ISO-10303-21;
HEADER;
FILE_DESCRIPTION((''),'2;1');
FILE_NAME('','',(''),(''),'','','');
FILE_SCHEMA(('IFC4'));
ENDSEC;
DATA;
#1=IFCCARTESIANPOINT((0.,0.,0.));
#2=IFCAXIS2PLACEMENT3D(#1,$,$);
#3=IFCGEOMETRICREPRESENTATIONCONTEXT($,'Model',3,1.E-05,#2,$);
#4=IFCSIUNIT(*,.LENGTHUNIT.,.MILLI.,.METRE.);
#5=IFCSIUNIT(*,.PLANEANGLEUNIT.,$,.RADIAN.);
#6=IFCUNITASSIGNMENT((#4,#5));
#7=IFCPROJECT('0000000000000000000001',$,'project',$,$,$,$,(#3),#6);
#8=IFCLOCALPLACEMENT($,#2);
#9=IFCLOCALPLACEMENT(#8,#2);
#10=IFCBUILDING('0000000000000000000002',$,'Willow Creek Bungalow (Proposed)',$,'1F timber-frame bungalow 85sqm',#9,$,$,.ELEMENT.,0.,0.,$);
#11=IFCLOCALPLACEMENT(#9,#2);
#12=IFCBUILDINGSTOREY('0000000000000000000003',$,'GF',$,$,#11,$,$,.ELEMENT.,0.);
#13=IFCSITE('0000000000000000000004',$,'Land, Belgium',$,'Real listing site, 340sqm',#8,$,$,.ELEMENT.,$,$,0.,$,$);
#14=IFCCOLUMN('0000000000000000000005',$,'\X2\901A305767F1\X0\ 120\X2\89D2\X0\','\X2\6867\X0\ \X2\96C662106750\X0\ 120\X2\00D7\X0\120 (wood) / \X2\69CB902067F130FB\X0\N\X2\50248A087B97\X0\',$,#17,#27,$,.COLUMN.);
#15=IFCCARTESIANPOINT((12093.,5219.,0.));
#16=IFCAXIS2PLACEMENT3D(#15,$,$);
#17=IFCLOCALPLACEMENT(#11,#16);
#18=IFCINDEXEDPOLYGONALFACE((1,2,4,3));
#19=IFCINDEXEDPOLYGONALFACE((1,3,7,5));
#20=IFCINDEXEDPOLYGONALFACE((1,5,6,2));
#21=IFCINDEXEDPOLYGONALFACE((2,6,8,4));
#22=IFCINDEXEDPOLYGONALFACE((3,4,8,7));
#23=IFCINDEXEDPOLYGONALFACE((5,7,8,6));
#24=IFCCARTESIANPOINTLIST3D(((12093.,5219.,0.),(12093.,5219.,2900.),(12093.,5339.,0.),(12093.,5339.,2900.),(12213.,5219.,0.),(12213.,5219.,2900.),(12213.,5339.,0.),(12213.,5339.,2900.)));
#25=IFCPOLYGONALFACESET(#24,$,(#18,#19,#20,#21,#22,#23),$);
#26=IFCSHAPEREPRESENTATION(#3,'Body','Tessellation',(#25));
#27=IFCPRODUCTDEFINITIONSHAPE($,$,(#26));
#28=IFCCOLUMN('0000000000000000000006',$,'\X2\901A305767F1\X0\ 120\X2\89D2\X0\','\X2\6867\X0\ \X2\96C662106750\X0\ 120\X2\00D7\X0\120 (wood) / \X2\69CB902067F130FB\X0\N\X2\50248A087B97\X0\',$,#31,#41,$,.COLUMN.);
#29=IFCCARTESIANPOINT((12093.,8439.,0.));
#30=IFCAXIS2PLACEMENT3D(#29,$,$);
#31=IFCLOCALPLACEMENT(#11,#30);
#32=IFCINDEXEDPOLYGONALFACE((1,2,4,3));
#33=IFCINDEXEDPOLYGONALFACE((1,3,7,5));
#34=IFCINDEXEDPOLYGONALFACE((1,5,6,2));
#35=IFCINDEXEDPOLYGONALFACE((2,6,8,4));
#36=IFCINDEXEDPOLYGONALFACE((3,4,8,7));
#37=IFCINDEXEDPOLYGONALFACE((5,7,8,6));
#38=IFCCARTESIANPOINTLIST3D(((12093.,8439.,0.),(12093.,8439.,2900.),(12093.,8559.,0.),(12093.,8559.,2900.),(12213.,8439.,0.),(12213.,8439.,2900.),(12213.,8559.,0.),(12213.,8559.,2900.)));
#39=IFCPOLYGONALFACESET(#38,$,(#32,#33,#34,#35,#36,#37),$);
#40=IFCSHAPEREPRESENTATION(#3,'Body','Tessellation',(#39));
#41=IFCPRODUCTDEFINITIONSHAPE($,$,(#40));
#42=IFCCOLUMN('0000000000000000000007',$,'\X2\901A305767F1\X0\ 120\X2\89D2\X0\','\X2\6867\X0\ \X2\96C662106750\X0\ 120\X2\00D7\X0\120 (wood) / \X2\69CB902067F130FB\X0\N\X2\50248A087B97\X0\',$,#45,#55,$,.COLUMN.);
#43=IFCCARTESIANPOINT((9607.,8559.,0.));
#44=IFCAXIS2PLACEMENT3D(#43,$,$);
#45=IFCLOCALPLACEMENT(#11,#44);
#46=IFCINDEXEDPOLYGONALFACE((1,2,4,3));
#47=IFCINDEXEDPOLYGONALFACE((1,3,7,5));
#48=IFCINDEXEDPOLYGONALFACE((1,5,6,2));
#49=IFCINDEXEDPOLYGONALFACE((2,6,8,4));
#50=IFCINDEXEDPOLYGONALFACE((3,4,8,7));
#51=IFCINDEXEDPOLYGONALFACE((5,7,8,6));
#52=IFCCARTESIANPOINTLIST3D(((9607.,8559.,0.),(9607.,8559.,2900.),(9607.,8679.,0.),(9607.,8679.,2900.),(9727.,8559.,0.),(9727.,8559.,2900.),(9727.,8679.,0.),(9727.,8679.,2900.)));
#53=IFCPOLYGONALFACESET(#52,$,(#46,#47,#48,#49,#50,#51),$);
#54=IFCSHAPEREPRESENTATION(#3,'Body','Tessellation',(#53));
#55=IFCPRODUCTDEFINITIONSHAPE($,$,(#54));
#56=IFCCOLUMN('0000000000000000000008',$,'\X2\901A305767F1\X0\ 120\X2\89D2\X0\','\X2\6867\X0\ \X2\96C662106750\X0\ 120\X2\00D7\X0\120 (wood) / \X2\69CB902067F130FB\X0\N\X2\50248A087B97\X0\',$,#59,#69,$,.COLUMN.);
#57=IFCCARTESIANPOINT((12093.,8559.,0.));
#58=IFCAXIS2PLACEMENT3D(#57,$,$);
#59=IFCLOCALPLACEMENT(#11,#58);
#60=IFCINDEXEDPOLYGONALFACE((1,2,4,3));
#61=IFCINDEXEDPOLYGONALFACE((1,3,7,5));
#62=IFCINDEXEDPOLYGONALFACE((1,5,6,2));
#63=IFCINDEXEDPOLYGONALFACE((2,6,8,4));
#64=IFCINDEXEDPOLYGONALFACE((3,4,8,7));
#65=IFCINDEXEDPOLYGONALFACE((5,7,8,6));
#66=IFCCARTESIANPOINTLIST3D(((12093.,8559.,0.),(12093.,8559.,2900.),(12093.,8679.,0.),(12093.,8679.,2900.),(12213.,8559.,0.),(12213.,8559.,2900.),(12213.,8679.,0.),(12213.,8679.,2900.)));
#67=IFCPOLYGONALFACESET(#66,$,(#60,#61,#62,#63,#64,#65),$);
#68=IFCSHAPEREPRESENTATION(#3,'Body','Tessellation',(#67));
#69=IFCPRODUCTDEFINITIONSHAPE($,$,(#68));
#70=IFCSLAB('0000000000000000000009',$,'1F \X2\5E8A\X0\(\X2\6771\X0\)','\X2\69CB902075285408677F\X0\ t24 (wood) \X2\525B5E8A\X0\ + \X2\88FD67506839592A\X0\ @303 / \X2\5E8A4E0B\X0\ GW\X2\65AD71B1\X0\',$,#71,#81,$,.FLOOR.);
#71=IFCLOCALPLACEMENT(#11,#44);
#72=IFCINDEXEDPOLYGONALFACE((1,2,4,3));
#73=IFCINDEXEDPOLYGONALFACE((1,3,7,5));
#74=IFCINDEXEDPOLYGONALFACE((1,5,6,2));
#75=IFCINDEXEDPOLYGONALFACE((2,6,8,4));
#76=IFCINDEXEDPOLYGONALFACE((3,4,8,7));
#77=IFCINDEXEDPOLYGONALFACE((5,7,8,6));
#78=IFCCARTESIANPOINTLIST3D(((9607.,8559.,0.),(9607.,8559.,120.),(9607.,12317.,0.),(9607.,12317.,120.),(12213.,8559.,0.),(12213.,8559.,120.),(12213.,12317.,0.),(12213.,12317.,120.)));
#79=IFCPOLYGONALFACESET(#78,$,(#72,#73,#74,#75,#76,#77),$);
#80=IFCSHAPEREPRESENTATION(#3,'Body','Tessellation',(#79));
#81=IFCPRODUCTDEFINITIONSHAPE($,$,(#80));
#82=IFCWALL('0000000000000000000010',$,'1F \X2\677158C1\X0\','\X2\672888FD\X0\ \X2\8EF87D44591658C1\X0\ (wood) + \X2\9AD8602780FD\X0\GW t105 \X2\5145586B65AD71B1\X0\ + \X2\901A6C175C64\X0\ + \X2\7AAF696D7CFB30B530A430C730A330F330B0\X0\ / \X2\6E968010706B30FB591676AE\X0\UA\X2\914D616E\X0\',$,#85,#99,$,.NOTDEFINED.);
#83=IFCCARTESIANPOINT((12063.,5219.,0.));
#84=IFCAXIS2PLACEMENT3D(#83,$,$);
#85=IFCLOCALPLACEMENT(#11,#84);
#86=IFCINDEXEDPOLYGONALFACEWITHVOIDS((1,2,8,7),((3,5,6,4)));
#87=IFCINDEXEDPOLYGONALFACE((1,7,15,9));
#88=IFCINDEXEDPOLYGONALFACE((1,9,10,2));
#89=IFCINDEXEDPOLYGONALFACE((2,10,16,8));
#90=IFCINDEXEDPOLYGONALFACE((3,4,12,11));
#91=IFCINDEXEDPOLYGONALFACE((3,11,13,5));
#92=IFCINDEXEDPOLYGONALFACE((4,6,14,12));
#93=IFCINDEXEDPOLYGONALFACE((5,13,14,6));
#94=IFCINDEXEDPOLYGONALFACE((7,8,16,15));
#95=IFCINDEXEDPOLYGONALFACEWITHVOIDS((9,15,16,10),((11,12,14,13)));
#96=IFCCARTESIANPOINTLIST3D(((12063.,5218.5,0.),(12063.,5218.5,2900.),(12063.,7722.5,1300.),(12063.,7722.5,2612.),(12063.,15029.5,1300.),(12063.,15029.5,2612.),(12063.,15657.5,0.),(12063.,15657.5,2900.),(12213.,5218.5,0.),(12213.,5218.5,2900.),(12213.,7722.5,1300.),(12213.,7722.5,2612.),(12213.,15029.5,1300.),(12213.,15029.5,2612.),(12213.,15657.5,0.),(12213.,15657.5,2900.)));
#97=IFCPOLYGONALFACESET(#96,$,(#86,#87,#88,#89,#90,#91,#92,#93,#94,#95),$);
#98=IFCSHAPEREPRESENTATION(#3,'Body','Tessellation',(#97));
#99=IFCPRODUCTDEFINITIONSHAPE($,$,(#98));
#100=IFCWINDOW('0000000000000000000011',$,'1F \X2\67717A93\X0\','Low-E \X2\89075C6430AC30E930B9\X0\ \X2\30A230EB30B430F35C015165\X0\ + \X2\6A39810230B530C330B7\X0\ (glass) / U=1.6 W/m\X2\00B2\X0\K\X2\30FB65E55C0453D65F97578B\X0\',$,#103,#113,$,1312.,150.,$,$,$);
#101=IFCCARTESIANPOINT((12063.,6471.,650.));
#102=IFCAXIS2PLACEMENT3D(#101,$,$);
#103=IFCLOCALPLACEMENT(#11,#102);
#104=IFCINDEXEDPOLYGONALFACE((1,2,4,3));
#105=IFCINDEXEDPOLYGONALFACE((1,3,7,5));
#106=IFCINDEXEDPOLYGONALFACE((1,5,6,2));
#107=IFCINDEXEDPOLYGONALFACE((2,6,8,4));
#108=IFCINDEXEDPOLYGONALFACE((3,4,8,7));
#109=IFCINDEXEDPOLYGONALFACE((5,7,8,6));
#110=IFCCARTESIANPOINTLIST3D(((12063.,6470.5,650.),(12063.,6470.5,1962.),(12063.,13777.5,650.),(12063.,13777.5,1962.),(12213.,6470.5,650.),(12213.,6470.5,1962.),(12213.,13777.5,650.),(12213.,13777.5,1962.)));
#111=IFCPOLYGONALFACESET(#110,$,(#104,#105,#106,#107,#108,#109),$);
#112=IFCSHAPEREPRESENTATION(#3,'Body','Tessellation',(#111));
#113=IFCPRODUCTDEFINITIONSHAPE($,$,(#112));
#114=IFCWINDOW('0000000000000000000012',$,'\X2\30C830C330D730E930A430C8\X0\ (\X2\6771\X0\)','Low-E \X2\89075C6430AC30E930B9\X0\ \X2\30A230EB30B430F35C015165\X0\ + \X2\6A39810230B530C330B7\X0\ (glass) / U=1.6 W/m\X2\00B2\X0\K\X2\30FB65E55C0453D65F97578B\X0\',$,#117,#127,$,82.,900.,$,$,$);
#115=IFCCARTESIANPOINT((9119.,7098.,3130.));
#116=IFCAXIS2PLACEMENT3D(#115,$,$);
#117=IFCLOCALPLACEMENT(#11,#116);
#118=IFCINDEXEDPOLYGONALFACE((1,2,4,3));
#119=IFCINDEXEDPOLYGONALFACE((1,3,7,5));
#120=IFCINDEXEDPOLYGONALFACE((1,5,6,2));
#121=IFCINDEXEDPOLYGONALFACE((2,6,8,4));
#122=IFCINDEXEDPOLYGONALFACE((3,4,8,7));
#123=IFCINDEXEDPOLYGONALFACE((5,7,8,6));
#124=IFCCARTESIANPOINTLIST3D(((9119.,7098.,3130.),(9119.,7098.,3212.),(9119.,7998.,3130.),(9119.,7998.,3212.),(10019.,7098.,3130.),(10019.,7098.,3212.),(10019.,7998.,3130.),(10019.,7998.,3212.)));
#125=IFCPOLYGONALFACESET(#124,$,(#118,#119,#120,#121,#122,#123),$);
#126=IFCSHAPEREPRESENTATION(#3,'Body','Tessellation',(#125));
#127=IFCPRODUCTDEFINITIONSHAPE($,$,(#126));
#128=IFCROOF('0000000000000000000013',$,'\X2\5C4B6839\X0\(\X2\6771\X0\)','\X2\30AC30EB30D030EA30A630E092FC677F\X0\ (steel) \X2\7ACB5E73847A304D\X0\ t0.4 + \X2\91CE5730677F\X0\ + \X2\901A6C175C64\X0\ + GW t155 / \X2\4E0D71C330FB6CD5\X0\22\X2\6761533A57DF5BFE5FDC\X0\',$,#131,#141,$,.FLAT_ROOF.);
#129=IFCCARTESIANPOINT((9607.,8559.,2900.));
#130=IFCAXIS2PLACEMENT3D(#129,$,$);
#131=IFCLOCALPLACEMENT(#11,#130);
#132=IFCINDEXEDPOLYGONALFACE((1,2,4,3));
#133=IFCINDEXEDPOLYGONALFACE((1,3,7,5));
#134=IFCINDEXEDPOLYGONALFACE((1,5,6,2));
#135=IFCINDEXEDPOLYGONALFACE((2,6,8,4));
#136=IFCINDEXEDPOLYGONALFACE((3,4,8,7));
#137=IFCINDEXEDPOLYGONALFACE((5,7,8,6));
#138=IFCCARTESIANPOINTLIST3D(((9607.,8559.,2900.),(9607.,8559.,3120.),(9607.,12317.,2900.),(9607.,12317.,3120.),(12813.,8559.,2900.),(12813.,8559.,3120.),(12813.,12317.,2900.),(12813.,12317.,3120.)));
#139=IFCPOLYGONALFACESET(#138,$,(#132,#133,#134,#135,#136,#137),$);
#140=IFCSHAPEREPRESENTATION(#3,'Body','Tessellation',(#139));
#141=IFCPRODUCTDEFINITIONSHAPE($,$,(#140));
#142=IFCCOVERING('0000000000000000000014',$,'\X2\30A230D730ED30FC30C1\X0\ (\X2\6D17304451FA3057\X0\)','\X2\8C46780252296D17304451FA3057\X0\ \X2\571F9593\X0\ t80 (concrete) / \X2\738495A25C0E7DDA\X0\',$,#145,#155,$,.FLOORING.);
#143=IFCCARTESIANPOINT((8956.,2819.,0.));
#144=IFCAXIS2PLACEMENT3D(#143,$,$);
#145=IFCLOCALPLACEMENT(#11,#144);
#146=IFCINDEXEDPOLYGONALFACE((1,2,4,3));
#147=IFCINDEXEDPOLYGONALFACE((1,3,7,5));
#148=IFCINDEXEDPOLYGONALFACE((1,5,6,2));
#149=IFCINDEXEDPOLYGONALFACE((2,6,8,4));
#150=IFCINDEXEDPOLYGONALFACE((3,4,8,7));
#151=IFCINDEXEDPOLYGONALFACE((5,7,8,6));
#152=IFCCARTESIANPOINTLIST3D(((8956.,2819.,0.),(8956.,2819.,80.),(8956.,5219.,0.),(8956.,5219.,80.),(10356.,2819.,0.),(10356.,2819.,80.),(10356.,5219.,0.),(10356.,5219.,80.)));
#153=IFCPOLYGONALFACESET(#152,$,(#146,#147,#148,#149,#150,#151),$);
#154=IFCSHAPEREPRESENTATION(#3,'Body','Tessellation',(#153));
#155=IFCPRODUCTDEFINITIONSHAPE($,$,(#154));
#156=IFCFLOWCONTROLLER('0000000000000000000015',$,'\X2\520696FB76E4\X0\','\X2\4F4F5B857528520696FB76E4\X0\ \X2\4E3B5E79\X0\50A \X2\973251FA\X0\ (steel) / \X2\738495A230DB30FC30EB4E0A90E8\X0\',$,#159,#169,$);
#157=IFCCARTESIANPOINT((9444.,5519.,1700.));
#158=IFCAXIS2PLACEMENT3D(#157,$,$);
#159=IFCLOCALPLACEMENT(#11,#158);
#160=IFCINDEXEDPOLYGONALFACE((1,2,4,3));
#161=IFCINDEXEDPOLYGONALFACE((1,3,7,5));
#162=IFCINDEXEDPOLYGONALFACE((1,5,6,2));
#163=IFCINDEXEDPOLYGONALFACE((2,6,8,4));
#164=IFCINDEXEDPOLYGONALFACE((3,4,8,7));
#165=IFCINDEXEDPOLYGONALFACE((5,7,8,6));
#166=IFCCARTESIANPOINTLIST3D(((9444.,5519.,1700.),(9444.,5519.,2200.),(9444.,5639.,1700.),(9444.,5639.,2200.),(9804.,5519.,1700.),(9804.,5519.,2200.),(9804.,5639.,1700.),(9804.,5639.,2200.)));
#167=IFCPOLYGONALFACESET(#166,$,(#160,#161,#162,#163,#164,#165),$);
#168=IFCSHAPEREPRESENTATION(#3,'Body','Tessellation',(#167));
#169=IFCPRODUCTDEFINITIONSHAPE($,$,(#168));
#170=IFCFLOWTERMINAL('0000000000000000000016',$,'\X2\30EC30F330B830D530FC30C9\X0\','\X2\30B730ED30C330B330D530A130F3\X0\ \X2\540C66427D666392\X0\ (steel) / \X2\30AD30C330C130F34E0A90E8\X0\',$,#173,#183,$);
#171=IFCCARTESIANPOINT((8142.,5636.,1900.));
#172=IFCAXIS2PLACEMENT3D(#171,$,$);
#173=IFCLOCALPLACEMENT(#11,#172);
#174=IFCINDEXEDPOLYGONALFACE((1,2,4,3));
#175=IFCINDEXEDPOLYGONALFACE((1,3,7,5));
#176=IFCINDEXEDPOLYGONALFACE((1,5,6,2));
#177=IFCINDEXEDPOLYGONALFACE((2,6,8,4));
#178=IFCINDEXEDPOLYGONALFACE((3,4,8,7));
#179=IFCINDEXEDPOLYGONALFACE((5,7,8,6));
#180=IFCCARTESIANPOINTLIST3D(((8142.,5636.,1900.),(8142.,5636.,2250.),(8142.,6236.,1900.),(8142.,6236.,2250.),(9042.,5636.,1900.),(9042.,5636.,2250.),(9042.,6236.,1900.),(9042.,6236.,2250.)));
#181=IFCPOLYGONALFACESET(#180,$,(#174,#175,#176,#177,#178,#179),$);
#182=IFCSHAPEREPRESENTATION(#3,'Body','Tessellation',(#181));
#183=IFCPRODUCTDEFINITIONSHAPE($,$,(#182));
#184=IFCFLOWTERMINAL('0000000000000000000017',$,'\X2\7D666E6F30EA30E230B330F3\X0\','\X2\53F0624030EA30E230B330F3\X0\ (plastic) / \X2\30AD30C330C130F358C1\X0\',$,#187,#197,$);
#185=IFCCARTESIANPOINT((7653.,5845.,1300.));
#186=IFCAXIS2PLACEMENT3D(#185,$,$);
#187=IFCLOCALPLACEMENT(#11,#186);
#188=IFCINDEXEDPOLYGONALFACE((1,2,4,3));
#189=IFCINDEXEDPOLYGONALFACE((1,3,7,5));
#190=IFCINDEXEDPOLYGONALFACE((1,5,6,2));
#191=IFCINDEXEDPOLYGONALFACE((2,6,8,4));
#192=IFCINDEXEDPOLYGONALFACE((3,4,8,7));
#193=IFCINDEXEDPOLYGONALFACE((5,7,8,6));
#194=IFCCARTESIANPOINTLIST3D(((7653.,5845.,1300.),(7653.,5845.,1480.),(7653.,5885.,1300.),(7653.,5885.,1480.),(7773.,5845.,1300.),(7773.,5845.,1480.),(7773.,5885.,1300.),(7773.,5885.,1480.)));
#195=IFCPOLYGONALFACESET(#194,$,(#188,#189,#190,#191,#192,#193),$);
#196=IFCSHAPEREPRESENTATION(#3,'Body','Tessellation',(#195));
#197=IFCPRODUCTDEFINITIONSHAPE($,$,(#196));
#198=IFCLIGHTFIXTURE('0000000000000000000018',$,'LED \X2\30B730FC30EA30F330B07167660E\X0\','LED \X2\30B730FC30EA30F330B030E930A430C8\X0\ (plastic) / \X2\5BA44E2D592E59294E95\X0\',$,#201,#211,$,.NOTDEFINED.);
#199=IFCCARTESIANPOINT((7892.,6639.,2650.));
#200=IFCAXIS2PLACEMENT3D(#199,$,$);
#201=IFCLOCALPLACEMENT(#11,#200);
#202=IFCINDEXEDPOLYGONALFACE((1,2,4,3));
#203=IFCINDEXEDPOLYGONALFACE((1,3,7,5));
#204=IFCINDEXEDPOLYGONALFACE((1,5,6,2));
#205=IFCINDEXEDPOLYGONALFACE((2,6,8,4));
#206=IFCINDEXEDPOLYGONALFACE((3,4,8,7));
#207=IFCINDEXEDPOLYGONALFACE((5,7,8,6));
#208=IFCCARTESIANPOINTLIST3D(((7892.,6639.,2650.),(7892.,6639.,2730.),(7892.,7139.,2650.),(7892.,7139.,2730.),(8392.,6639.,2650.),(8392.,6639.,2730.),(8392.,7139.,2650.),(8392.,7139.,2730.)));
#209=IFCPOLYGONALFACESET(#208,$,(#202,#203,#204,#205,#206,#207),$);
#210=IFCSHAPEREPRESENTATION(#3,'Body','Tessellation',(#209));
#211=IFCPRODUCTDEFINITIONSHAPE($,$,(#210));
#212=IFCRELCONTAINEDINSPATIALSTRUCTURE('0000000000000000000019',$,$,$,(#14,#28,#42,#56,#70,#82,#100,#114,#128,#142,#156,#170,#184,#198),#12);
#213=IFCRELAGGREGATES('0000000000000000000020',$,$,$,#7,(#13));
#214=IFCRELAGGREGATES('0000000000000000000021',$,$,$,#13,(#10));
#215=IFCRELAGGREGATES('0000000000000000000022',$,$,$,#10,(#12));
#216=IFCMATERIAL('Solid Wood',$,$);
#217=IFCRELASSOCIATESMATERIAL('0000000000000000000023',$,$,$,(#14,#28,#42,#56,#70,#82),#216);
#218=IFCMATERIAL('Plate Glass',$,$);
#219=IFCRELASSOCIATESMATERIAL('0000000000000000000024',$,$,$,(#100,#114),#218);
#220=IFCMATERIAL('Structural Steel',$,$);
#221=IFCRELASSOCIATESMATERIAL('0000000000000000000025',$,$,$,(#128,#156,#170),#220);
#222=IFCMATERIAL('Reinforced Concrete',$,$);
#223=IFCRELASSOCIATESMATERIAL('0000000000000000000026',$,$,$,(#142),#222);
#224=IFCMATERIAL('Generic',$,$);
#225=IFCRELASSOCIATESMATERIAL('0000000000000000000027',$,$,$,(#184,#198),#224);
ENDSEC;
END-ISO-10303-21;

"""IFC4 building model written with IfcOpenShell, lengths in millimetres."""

from ifc_helpers import new_model, si_unit, frame, frame_2d, origin, place, context, project, spatial, rectangle, extrude, material, element, fill, save


model = new_model("IFC4")

# Units and contexts
model_context = context("Model", 3, precision=1e-05, world=origin())
ifc_project = project(units=[si_unit("LENGTHUNIT", "METRE", prefix="MILLI"), si_unit("PLANEANGLEUNIT", "RADIAN")], contexts=[model_context])

# Site, building, storey
site_placement = place(None, origin())
site = spatial("IfcSite", under=ifc_project, at=site_placement, Name="Land, Belgium", ObjectType="Real listing site, 340sqm", CompositionType="ELEMENT", RefElevation=0.0)
building_placement = place(site_placement, origin())
building = spatial("IfcBuilding", under=site, at=building_placement, Name="Willow Creek Bungalow (Proposed)", ObjectType="1F timber-frame bungalow 85sqm", CompositionType="ELEMENT", ElevationOfRefHeight=0.0, ElevationOfTerrain=0.0)
storey_placement = place(building_placement, origin())
storey = spatial("IfcBuildingStorey", under=building, at=storey_placement, Name="GF", CompositionType="ELEMENT", Elevation=0.0)

# Columns
ifc_material_1 = material(Name="Solid Wood")
column_1_placement = place(storey_placement, frame((12093.0, 5219.0, 0.0)))
element("IfcColumn", 1, at=column_1_placement, inside=storey, material=ifc_material_1, Name="通し柱 120角", Description="桧 集成材 120×120 (wood) / 構造柱・N値計算", PredefinedType="COLUMN", context=model_context, shape_type="SweptSolid", body=[
    extrude(rectangle(XDim=120.0, YDim=120.0, at=frame_2d((60.0, 60.0))), frame((12093.0, 5219.0, 0.0)), (0.0, 0.0, 1.0), 2900.0),
])
column_2_placement = place(storey_placement, frame((12093.0, 8439.0, 0.0)))
element("IfcColumn", 2, at=column_2_placement, inside=storey, material=ifc_material_1, Name="通し柱 120角", Description="桧 集成材 120×120 (wood) / 構造柱・N値計算", PredefinedType="COLUMN", context=model_context, shape_type="SweptSolid", body=[
    extrude(rectangle(XDim=120.0, YDim=120.0, at=frame_2d((60.0, 60.0))), frame((12093.0, 8439.0, 0.0)), (0.0, 0.0, 1.0), 2900.0),
])
column_3_placement = place(storey_placement, frame((9607.0, 8559.0, 0.0)))
element("IfcColumn", 3, at=column_3_placement, inside=storey, material=ifc_material_1, Name="通し柱 120角", Description="桧 集成材 120×120 (wood) / 構造柱・N値計算", PredefinedType="COLUMN", context=model_context, shape_type="SweptSolid", body=[
    extrude(rectangle(XDim=120.0, YDim=120.0, at=frame_2d((60.0, 60.0))), frame((9607.0, 8559.0, 0.0)), (0.0, 0.0, 1.0), 2900.0),
])
column_4_placement = place(storey_placement, frame((12093.0, 8559.0, 0.0)))
element("IfcColumn", 4, at=column_4_placement, inside=storey, material=ifc_material_1, Name="通し柱 120角", Description="桧 集成材 120×120 (wood) / 構造柱・N値計算", PredefinedType="COLUMN", context=model_context, shape_type="SweptSolid", body=[
    extrude(rectangle(XDim=120.0, YDim=120.0, at=frame_2d((60.0, 60.0))), frame((12093.0, 8559.0, 0.0)), (0.0, 0.0, 1.0), 2900.0),
])

# Slab
slab_placement = place(storey_placement, frame((9607.0, 8559.0, 0.0)))
element("IfcSlab", 5, at=slab_placement, inside=storey, material=ifc_material_1, Name="1F 床(東)", Description="構造用合板 t24 (wood) 剛床 + 製材根太 @303 / 床下 GW断熱", PredefinedType="FLOOR", context=model_context, shape_type="SweptSolid", body=[
    extrude(rectangle(XDim=2606.0, YDim=3758.0, at=frame_2d((1303.0, 1879.0))), frame((9607.0, 8559.0, 0.0)), (0.0, 0.0, 1.0), 120.0),
])

# Wall, opening, window
wall_1_placement = place(storey_placement, frame((12063.0, 5219.0, 0.0)))
wall_1 = element("IfcWall", 6, at=wall_1_placement, inside=storey, material=ifc_material_1, Name="1F 東壁", Description="木製 軸組外壁 (wood) + 高性能GW t105 充填断熱 + 通気層 + 窯業系サイディング / 準耐火・外皮UA配慮", PredefinedType="NOTDEFINED", context=model_context, shape_type="SweptSolid", body=[
    extrude(rectangle(XDim=150.0, YDim=10439.0, at=frame_2d((75.0, 5219.0))), frame((12063.0, 5219.0, 0.0)), (0.0, 0.0, 1.0), 2900.0),
])
opening_placement = place(storey_placement, frame((12063.0, 6471.0, 650.0)))
opening = element("IfcOpeningElement", 7, at=opening_placement, cuts=wall_1, PredefinedType="NOTDEFINED", context=model_context, shape_type="SweptSolid", body=[
    extrude(rectangle(XDim=150.0, YDim=7307.0, at=frame_2d((75.0, 3653.0))), frame((12063.0, 6471.0, 650.0)), (0.0, 0.0, 1.0), 1312.0),
])
ifc_material_2 = material(Name="Plate Glass")
window_1_placement = place(storey_placement, frame((12063.0, 6471.0, 650.0)))
window_1 = element("IfcWindow", 8, at=window_1_placement, inside=storey, material=ifc_material_2, Name="1F 東窓", Description="Low-E 複層ガラス アルゴン封入 + 樹脂サッシ (glass) / U=1.6 W/m²K・日射取得型", OverallHeight=1312.0, OverallWidth=150.0, context=model_context, shape_type="SweptSolid", body=[
    extrude(rectangle(XDim=150.0, YDim=7307.0, at=frame_2d((75.0, 3653.0))), frame((12063.0, 6471.0, 650.0)), (0.0, 0.0, 1.0), 1312.0),
])
fill(opening, window_1)

# Window
window_2_placement = place(storey_placement, frame((9119.0, 7098.0, 3130.0)))
element("IfcWindow", 9, at=window_2_placement, inside=storey, material=ifc_material_2, Name="トップライト (東)", Description="Low-E 複層ガラス アルゴン封入 + 樹脂サッシ (glass) / U=1.6 W/m²K・日射取得型", OverallHeight=82.0, OverallWidth=900.0, context=model_context, shape_type="SweptSolid", body=[
    extrude(rectangle(XDim=900.0, YDim=900.0, at=frame_2d((450.0, 450.0))), frame((9119.0, 7098.0, 3130.0)), (0.0, 0.0, 1.0), 82.0),
])

# Roof
ifc_material_3 = material(Name="Structural Steel")
roof_placement = place(storey_placement, frame((9607.0, 8559.0, 2900.0)))
element("IfcRoof", 10, at=roof_placement, inside=storey, material=ifc_material_3, Name="屋根(東)", Description="ガルバリウム鋼板 (steel) 立平葺き t0.4 + 野地板 + 通気層 + GW t155 / 不燃・法22条区域対応", PredefinedType="FLAT_ROOF", context=model_context, shape_type="SweptSolid", body=[
    extrude(rectangle(XDim=3206.0, YDim=3758.0, at=frame_2d((1603.0, 1879.0))), frame((9607.0, 8559.0, 2900.0)), (0.0, 0.0, 1.0), 220.0),
])

# Covering
ifc_material_4 = material(Name="Reinforced Concrete")
covering_placement = place(storey_placement, frame((8956.0, 2819.0, 0.0)))
element("IfcCovering", 11, at=covering_placement, inside=storey, material=ifc_material_4, Name="アプローチ (洗い出し)", Description="豆砂利洗い出し 土間 t80 (concrete) / 玄関導線", PredefinedType="FLOORING", context=model_context, shape_type="SweptSolid", body=[
    extrude(rectangle(XDim=1400.0, YDim=2400.0, at=frame_2d((700.0, 1200.0))), frame((8956.0, 2819.0, 0.0)), (0.0, 0.0, 1.0), 80.0),
])

# Flow controller
flow_controller_placement = place(storey_placement, frame((9444.0, 5519.0, 1700.0)))
element("IfcFlowController", 12, at=flow_controller_placement, inside=storey, material=ifc_material_3, Name="分電盤", Description="住宅用分電盤 主幹50A 露出 (steel) / 玄関ホール上部", context=model_context, shape_type="SweptSolid", body=[
    extrude(rectangle(XDim=360.0, YDim=120.0, at=frame_2d((180.0, 60.0))), frame((9444.0, 5519.0, 1700.0)), (0.0, 0.0, 1.0), 500.0),
])

# Flow terminals
flow_terminal_1_placement = place(storey_placement, frame((8142.0, 5636.0, 1900.0)))
element("IfcFlowTerminal", 13, at=flow_terminal_1_placement, inside=storey, material=ifc_material_3, Name="レンジフード", Description="シロッコファン 同時給排 (steel) / キッチン上部", context=model_context, shape_type="SweptSolid", body=[
    extrude(rectangle(XDim=900.0, YDim=600.0, at=frame_2d((450.0, 300.0))), frame((8142.0, 5636.0, 1900.0)), (0.0, 0.0, 1.0), 350.0),
])
ifc_material_5 = material(Name="Generic")
flow_terminal_2_placement = place(storey_placement, frame((7653.0, 5845.0, 1300.0)))
element("IfcFlowTerminal", 14, at=flow_terminal_2_placement, inside=storey, material=ifc_material_5, Name="給湯リモコン", Description="台所リモコン (plastic) / キッチン壁", context=model_context, shape_type="SweptSolid", body=[
    extrude(rectangle(XDim=120.0, YDim=40.0, at=frame_2d((60.0, 20.0))), frame((7653.0, 5845.0, 1300.0)), (0.0, 0.0, 1.0), 180.0),
])

# Light fixture
light_fixture_placement = place(storey_placement, frame((7892.0, 6639.0, 2650.0)))
element("IfcLightFixture", 15, at=light_fixture_placement, inside=storey, material=ifc_material_5, Name="LED シーリング照明", Description="LED シーリングライト (plastic) / 室中央天井", PredefinedType="NOTDEFINED", context=model_context, shape_type="SweptSolid", body=[
    extrude(rectangle(XDim=500.0, YDim=500.0, at=frame_2d((250.0, 250.0))), frame((7892.0, 6639.0, 2650.0)), (0.0, 0.0, 1.0), 80.0),
])

save(model, "model.ifc")
